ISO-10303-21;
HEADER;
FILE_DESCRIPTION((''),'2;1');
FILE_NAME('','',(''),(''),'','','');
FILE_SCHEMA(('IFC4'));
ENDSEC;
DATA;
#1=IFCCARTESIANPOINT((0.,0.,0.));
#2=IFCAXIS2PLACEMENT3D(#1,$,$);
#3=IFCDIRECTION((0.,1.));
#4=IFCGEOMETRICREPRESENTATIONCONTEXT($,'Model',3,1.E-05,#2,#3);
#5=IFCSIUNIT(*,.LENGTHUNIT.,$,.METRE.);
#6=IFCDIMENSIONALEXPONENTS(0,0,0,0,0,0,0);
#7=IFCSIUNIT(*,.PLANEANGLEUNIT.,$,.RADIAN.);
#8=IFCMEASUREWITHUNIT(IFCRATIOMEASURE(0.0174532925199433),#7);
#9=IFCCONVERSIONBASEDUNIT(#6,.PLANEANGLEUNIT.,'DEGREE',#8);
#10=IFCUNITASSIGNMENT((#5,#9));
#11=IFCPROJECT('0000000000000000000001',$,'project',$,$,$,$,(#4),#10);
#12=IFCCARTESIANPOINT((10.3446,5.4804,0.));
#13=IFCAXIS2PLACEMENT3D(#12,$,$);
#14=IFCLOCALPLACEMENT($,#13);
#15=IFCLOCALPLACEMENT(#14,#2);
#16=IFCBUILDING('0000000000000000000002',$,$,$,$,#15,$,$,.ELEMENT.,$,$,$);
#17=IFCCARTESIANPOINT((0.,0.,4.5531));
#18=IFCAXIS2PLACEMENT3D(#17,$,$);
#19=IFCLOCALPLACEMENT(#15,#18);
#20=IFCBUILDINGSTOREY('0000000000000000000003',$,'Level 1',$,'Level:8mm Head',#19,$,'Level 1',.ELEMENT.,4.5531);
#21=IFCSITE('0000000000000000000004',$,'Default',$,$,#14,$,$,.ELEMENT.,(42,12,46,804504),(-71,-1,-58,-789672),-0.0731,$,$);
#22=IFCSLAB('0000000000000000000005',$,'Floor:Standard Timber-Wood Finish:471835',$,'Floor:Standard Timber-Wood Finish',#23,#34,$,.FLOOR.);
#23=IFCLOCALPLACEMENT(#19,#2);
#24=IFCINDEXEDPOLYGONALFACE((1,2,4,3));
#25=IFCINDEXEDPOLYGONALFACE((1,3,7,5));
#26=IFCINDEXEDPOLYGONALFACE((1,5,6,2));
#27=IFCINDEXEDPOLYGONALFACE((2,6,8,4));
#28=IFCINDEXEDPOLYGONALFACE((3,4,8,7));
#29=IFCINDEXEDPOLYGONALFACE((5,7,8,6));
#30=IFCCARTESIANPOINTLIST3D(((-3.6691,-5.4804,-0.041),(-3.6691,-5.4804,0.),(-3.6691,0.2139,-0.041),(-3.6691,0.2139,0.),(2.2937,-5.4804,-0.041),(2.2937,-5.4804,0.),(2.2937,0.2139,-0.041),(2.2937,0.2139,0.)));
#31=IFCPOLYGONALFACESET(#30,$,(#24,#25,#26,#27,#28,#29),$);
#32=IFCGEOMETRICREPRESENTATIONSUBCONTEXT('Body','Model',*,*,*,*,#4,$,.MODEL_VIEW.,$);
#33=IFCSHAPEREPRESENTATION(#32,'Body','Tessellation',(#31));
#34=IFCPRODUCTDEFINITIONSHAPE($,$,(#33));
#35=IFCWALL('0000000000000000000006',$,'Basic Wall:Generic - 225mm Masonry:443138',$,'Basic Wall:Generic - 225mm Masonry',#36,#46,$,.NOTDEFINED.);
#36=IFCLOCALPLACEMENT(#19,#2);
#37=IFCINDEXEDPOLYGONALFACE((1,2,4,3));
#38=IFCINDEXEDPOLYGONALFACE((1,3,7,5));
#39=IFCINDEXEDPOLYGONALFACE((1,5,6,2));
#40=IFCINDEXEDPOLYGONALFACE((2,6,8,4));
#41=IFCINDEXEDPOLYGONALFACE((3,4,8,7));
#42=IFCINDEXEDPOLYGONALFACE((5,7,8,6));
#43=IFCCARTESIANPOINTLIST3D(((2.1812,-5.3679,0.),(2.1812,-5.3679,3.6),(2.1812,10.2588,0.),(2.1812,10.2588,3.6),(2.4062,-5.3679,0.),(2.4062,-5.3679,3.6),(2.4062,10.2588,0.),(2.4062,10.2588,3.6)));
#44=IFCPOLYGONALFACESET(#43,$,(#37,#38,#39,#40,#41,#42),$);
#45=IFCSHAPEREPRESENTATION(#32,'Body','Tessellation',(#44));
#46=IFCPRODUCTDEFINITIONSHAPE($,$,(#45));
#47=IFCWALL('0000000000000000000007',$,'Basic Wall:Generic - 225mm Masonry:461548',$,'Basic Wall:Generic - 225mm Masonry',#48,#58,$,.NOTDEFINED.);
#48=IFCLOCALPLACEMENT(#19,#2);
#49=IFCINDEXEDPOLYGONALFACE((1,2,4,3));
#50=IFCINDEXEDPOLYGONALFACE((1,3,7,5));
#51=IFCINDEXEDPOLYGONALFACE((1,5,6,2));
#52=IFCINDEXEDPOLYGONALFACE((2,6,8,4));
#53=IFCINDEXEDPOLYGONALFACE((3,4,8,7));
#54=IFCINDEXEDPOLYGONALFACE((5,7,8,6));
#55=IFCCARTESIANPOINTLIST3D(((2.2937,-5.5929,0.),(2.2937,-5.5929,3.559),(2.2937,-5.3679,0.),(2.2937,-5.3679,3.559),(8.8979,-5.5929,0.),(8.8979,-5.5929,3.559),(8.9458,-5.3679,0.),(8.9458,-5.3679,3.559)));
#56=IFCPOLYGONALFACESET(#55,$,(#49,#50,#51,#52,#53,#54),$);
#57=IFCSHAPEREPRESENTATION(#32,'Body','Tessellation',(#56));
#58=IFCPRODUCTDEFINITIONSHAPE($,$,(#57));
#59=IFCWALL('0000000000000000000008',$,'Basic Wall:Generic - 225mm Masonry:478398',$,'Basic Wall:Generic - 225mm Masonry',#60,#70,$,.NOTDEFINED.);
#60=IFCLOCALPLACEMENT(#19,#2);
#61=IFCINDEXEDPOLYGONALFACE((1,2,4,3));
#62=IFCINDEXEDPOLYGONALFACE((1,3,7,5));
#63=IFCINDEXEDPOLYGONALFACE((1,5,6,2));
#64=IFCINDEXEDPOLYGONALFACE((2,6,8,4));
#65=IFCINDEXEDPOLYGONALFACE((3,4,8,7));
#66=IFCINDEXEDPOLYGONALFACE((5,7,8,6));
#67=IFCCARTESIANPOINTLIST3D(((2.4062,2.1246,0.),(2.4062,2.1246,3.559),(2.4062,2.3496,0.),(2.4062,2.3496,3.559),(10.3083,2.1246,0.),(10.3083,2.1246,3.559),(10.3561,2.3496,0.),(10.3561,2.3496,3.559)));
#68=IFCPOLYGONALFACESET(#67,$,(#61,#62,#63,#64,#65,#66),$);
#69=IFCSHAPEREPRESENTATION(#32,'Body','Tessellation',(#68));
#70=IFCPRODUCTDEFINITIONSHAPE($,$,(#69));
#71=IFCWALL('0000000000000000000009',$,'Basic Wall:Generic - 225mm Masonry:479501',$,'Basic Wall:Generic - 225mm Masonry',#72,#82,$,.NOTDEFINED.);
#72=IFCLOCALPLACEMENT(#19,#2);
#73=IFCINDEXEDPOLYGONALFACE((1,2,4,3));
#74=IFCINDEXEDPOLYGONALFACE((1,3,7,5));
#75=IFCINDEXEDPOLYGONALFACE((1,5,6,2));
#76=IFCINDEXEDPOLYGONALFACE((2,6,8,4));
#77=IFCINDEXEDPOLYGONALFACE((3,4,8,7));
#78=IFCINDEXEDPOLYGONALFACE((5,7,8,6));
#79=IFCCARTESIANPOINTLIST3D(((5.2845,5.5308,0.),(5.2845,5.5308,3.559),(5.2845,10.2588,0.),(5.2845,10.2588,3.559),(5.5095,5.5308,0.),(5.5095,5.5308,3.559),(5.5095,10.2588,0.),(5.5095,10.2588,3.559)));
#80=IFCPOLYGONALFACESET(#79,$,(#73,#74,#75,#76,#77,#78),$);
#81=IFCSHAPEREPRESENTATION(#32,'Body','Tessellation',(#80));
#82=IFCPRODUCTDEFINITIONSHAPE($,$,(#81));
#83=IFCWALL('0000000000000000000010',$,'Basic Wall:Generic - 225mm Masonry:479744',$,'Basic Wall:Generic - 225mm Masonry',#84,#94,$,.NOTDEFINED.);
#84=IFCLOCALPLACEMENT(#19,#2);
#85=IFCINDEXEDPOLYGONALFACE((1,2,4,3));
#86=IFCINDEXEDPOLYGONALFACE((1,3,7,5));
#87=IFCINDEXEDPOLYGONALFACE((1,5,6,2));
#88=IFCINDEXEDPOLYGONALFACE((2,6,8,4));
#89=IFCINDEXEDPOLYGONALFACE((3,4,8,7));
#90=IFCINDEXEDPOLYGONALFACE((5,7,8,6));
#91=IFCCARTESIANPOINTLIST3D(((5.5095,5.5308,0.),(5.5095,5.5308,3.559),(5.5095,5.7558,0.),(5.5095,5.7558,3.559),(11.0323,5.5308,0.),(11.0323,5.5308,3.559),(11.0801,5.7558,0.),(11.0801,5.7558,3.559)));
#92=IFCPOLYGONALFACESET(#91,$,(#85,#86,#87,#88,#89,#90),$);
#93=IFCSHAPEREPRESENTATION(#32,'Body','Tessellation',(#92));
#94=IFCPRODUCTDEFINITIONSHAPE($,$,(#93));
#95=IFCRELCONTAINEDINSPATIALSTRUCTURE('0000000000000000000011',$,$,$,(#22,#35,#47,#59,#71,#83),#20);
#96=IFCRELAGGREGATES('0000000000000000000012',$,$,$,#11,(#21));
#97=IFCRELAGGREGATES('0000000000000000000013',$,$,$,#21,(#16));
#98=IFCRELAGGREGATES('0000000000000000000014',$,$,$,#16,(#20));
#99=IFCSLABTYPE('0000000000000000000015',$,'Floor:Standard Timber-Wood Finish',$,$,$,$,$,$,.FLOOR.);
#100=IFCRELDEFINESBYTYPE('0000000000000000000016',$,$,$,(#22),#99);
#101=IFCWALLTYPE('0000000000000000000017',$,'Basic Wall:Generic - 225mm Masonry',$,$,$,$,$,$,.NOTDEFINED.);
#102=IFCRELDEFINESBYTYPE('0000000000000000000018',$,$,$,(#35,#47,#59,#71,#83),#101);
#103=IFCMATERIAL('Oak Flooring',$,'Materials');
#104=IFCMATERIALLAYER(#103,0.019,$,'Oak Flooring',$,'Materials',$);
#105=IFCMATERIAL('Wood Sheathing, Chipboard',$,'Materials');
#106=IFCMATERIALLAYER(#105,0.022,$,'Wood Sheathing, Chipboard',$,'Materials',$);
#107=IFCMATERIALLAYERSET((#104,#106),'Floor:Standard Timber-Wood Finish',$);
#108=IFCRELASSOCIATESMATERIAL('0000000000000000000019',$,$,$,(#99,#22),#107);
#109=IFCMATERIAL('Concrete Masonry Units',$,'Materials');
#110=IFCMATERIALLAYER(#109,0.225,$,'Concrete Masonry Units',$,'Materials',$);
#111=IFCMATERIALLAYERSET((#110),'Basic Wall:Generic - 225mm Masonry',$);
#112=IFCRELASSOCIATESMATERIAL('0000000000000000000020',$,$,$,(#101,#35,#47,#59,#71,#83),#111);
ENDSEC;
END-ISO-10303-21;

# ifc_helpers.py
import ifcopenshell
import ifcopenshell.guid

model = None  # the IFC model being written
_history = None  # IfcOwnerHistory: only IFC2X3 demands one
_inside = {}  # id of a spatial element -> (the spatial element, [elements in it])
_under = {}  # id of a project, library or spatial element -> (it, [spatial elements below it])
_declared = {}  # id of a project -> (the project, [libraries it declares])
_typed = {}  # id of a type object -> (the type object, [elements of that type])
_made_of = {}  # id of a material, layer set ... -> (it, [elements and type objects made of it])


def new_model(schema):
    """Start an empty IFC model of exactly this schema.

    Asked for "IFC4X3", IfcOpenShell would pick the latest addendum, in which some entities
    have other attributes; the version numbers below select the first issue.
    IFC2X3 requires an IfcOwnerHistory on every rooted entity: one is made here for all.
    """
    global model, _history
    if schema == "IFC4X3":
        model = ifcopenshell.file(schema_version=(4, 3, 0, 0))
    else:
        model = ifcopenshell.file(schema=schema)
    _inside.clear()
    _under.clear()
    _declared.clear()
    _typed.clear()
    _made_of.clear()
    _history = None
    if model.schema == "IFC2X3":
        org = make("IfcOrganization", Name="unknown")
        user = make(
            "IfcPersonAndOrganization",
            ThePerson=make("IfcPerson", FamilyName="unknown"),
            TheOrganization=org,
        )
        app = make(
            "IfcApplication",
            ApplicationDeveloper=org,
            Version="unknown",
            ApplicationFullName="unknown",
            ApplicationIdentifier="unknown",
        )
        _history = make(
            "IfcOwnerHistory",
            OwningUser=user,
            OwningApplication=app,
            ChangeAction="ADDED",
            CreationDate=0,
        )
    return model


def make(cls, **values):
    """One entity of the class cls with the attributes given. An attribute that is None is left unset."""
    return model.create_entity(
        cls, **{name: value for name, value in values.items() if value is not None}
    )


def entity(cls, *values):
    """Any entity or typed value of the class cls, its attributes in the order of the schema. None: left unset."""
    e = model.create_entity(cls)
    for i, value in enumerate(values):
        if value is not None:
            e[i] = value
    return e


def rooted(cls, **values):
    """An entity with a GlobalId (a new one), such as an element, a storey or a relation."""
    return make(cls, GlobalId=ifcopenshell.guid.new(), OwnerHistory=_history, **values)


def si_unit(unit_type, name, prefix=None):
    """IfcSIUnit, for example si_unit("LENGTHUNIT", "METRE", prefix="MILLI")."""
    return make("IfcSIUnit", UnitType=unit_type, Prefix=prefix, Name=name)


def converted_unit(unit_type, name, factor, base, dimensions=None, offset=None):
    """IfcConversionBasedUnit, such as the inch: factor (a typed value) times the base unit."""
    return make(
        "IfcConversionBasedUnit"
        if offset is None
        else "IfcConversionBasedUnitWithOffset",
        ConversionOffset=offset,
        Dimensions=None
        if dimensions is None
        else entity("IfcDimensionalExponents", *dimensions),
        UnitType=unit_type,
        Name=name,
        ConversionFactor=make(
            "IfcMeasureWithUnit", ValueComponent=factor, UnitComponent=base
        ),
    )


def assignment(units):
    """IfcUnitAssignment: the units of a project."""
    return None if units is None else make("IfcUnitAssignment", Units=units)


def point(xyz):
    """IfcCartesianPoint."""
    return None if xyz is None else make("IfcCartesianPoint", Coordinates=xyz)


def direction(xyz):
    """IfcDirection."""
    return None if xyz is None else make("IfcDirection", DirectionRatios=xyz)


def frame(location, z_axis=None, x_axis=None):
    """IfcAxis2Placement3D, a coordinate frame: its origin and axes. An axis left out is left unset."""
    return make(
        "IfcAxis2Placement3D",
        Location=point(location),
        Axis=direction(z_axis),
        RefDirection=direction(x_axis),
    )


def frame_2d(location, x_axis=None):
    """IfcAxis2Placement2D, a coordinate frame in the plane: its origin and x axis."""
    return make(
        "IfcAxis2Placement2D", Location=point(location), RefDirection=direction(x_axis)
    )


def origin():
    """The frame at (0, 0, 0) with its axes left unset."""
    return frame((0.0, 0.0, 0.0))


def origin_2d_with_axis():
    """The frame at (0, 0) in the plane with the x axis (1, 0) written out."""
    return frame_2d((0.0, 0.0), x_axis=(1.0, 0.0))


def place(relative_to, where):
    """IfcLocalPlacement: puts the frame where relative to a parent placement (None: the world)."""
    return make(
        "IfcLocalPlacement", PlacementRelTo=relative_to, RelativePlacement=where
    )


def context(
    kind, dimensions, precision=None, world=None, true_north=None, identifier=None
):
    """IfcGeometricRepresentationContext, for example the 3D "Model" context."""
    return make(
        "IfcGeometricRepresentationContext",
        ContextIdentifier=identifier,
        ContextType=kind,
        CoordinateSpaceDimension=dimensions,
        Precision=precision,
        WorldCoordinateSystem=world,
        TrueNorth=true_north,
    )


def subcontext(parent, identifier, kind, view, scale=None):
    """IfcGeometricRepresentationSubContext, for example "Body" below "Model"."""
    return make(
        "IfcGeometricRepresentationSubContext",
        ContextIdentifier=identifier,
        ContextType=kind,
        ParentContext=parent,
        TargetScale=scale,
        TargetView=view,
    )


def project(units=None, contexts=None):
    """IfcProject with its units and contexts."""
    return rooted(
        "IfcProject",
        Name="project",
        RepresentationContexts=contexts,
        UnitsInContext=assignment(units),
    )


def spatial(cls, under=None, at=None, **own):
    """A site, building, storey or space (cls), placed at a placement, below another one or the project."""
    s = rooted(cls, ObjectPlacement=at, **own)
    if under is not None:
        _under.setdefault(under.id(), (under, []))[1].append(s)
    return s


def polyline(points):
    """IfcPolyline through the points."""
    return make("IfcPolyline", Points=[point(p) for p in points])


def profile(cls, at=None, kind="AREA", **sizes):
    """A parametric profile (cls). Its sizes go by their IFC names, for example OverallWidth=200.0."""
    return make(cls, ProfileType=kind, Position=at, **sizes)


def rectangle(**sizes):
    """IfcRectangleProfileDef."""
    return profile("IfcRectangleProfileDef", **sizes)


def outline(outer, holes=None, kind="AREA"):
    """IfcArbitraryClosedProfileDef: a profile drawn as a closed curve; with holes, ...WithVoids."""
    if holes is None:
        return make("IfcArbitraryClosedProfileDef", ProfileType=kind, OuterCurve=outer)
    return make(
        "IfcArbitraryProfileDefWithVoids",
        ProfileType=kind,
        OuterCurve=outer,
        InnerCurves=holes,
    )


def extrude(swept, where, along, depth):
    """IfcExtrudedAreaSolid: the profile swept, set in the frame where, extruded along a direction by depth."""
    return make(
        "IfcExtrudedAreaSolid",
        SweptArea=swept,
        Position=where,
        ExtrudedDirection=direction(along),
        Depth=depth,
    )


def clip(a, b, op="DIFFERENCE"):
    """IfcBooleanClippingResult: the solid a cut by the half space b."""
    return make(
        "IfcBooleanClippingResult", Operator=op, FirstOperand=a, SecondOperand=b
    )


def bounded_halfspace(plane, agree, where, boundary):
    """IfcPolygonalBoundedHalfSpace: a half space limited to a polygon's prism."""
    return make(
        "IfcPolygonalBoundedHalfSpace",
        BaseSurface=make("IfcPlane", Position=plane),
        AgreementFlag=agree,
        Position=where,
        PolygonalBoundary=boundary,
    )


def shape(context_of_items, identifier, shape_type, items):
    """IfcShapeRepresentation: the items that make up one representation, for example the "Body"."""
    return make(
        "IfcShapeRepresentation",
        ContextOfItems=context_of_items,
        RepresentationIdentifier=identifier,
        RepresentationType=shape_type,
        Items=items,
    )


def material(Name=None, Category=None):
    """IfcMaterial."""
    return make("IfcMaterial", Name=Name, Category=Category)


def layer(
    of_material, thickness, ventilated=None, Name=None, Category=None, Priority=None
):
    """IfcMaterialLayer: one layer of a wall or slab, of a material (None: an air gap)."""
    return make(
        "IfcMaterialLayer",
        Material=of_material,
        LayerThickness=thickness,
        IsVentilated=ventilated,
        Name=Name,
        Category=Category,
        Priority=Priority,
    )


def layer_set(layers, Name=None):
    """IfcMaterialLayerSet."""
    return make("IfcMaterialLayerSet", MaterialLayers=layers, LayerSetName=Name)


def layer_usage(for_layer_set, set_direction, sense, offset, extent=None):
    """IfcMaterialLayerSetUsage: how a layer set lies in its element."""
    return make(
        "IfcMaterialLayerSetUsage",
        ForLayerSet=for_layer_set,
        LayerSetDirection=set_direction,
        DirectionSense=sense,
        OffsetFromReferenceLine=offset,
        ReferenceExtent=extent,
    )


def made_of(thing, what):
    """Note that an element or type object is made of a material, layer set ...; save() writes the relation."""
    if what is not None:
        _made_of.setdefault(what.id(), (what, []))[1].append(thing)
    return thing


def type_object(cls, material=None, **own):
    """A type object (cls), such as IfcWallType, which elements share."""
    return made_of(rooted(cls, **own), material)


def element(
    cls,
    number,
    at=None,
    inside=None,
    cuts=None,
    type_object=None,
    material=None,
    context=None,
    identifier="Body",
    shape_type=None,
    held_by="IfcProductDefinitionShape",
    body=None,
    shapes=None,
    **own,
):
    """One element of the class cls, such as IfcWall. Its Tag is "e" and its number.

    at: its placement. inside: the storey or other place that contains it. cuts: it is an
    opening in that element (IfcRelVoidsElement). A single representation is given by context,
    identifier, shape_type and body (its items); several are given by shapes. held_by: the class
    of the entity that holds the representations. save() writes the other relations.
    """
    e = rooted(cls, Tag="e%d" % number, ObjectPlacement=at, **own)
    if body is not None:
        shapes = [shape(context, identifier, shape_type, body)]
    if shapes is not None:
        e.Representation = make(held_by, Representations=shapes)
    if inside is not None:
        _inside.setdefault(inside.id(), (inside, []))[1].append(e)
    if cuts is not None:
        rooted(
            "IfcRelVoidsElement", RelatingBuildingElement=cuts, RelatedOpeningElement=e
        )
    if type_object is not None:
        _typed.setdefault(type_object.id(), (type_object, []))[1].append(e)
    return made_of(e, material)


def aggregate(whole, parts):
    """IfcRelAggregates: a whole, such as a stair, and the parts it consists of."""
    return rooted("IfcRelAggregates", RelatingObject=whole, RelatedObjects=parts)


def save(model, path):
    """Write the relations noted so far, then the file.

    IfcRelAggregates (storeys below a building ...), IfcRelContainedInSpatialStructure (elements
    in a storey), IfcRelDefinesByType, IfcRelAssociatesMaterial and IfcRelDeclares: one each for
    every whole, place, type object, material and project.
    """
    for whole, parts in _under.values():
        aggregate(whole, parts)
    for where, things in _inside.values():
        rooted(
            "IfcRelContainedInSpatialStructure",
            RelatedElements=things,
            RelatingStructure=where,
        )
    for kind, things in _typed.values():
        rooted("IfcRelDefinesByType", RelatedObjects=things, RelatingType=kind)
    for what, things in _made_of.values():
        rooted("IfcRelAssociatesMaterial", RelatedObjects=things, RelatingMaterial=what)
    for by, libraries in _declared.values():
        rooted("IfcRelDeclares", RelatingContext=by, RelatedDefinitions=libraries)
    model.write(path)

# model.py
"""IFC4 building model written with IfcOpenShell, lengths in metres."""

from ifc_helpers import new_model, entity, si_unit, converted_unit, direction, frame, frame_2d, origin, origin_2d_with_axis, place, context, subcontext, project, spatial, polyline, rectangle, outline, extrude, clip, bounded_halfspace, material, layer, layer_set, layer_usage, type_object, element, save


model = new_model("IFC4")

# Units and contexts
model_context = context("Model", 3, precision=1e-05, world=origin(), true_north=direction((0.0, 1.0)))
body_context = subcontext(model_context, "Body", "Model", "MODEL_VIEW")
ifc_project = project(units=[si_unit("LENGTHUNIT", "METRE"), converted_unit("PLANEANGLEUNIT", "DEGREE", entity("IfcRatioMeasure", 0.0174532925199433), si_unit("PLANEANGLEUNIT", "RADIAN"), dimensions=[0, 0, 0, 0, 0, 0, 0])], contexts=[model_context])

# Site, building, storey
site_placement = place(None, frame((10.3446, 5.4804, 0.0)))
site = spatial("IfcSite", under=ifc_project, at=site_placement, Name="Default", CompositionType="ELEMENT", RefLatitude=(42, 12, 46, 804504), RefLongitude=(-71, -1, -58, -789672), RefElevation=-0.0731)
building_placement = place(site_placement, origin())
building = spatial("IfcBuilding", under=site, at=building_placement, CompositionType="ELEMENT")
storey_placement = place(building_placement, frame((0.0, 0.0, 4.5531)))
storey = spatial("IfcBuildingStorey", under=building, at=storey_placement, Name="Level 1", ObjectType="Level:8mm Head", LongName="Level 1", CompositionType="ELEMENT", Elevation=4.5531)

# Slab
ifc_material_1 = material(Name="Oak Flooring", Category="Materials")
ifc_layer_1 = layer(ifc_material_1, 0.019, Name="Oak Flooring", Category="Materials")
ifc_material_2 = material(Name="Wood Sheathing, Chipboard", Category="Materials")
ifc_layer_2 = layer(ifc_material_2, 0.022, Name="Wood Sheathing, Chipboard", Category="Materials")
ifc_layer_set_1 = layer_set([ifc_layer_1, ifc_layer_2], Name="Floor:Standard Timber-Wood Finish")
ifc_layer_usage_1 = layer_usage(ifc_layer_set_1, "AXIS3", "POSITIVE", 0.0)
slab_type_1 = type_object("IfcSlabType", Name="Floor:Standard Timber-Wood Finish", PredefinedType="FLOOR", material=ifc_layer_set_1)
slab_1_placement = place(storey_placement, origin())
element("IfcSlab", 1, at=slab_1_placement, inside=storey, type_object=slab_type_1, material=ifc_layer_usage_1, Name="Floor:Standard Timber-Wood Finish:471835", ObjectType="Floor:Standard Timber-Wood Finish", PredefinedType="FLOOR", context=body_context, shape_type="SweptSolid", body=[
    extrude(rectangle(XDim=5.6943, YDim=5.9627, at=origin_2d_with_axis()), frame((-0.6877, -2.6333, 0.0), z_axis=(0.0, 0.0, -1.0), x_axis=(0.0, 1.0, 0.0)), (0.0, 0.0, 1.0), 0.041),
])

# Walls
ifc_material_3 = material(Name="Concrete Masonry Units", Category="Materials")
ifc_layer_3 = layer(ifc_material_3, 0.225, Name="Concrete Masonry Units", Category="Materials")
ifc_layer_set_2 = layer_set([ifc_layer_3], Name="Basic Wall:Generic - 225mm Masonry")
wall_type = type_object("IfcWallType", Name="Basic Wall:Generic - 225mm Masonry", PredefinedType="NOTDEFINED", material=ifc_layer_set_2)
ifc_layer_usage_2 = layer_usage(ifc_layer_set_2, "AXIS2", "NEGATIVE", 0.1125)
wall_1_placement = place(storey_placement, frame((2.2937, 10.2588, 0.0), z_axis=(0.0, 0.0, 1.0), x_axis=(0.0, -1.0, 0.0)))
element("IfcWall", 2, at=wall_1_placement, inside=storey, type_object=wall_type, material=ifc_layer_usage_2, Name="Basic Wall:Generic - 225mm Masonry:443138", ObjectType="Basic Wall:Generic - 225mm Masonry", PredefinedType="NOTDEFINED", context=body_context, shape_type="SweptSolid", body=[
    extrude(rectangle(XDim=15.6267, YDim=0.225, at=frame_2d((7.8134, 0.0), x_axis=(-1.0, 0.0))), origin(), (0.0, 0.0, 1.0), 3.6),
])
ifc_layer_usage_3 = layer_usage(ifc_layer_set_2, "AXIS2", "NEGATIVE", 0.1125)
wall_2_placement = place(storey_placement, frame((2.2937, -5.4804, 0.0)))
element("IfcWall", 3, at=wall_2_placement, inside=storey, type_object=wall_type, material=ifc_layer_usage_3, Name="Basic Wall:Generic - 225mm Masonry:461548", ObjectType="Basic Wall:Generic - 225mm Masonry", PredefinedType="NOTDEFINED", context=body_context, shape_type="Clipping", body=[
    clip(extrude(outline(polyline([(6.6043, -0.1125), (6.6521, 0.1125), (6.4221, 0.1125), (0.1125, 0.1125), (0.0, 0.1125), (0.0, -0.1125), (6.6043, -0.1125)])), origin(), (0.0, 0.0, 1.0), 3.559), bounded_halfspace(frame((6.5371, 0.1125, 3.559), z_axis=(0.0, 0.0, -1.0), x_axis=(-1.0, 0.0, 0.0)), True, frame((6.5371, 0.1125, 3.559)), polyline([(0.0, 0.0), (-0.115, 0.0), (-6.4246, 0.0), (-6.5371, 0.0), (-6.5371, -0.1125), (-0.0239, -0.1125), (0.0, 0.0)]))),
])
ifc_layer_usage_4 = layer_usage(ifc_layer_set_2, "AXIS2", "NEGATIVE", 0.1125)
wall_3_placement = place(storey_placement, frame((2.4062, 2.2371, 0.0)))
element("IfcWall", 4, at=wall_3_placement, inside=storey, type_object=wall_type, material=ifc_layer_usage_4, Name="Basic Wall:Generic - 225mm Masonry:478398", ObjectType="Basic Wall:Generic - 225mm Masonry", PredefinedType="NOTDEFINED", context=body_context, shape_type="Clipping", body=[
    clip(clip(extrude(outline(polyline([(7.9022, -0.1125), (7.95, 0.1125), (0.0, 0.1125), (0.0, -0.1125), (7.9022, -0.1125)])), origin(), (0.0, 0.0, 1.0), 3.559), bounded_halfspace(frame((7.9261, 0.0, 3.559), z_axis=(0.0, 0.0, -1.0), x_axis=(-0.207912, -0.978148, 0.0)), True, frame((7.9261, 0.0, 3.559)), polyline([(0.0, 0.0), (0.0239, 0.1125), (-7.9261, 0.1125), (-7.9261, 0.0), (0.0, 0.0)]))), bounded_halfspace(frame((0.0, -0.1125, 3.559), z_axis=(0.0, 0.0, -1.0), x_axis=(-1.0, 0.0, 0.0)), True, frame((0.0, -0.1125, 3.559)), polyline([(0.0, 0.0), (7.9022, 0.0), (7.9261, 0.1125), (0.0, 0.1125), (0.0, 0.0)]))),
])
ifc_layer_usage_5 = layer_usage(ifc_layer_set_2, "AXIS2", "NEGATIVE", 0.1125)
wall_4_placement = place(storey_placement, frame((5.397, 10.2588, 0.0), z_axis=(0.0, 0.0, 1.0), x_axis=(0.0, -1.0, 0.0)))
element("IfcWall", 5, at=wall_4_placement, inside=storey, type_object=wall_type, material=ifc_layer_usage_5, Name="Basic Wall:Generic - 225mm Masonry:479501", ObjectType="Basic Wall:Generic - 225mm Masonry", PredefinedType="NOTDEFINED", context=body_context, shape_type="Clipping", body=[
    clip(extrude(rectangle(XDim=4.728, YDim=0.225, at=frame_2d((2.364, 0.0), x_axis=(-1.0, 0.0))), origin(), (0.0, 0.0, 1.0), 3.559), bounded_halfspace(frame((0.0, -0.1125, 3.559), z_axis=(0.0, 0.0, -1.0), x_axis=(0.978148, -0.207912, 0.0)), True, frame((0.0, -0.1125, 3.559)), polyline([(0.0, 0.0), (4.728, 0.0), (4.728, 0.225), (4.503, 0.225), (0.0, 0.225), (0.0, 0.0)]))),
])
ifc_layer_usage_6 = layer_usage(ifc_layer_set_2, "AXIS2", "NEGATIVE", 0.1125)
wall_5_placement = place(storey_placement, frame((5.5095, 5.6433, 0.0)))
element("IfcWall", 6, at=wall_5_placement, inside=storey, type_object=wall_type, material=ifc_layer_usage_6, Name="Basic Wall:Generic - 225mm Masonry:479744", ObjectType="Basic Wall:Generic - 225mm Masonry", PredefinedType="NOTDEFINED", context=body_context, shape_type="Clipping", body=[
    clip(extrude(outline(polyline([(5.5228, -0.1125), (5.5706, 0.1125), (0.0, 0.1125), (0.0, -0.1125), (5.5228, -0.1125)])), origin(), (0.0, 0.0, 1.0), 3.559), bounded_halfspace(frame((0.0, -0.1125, 3.559), z_axis=(0.0, 0.0, -1.0), x_axis=(-0.207912, -0.978148, 0.0)), True, frame((0.0, -0.1125, 3.559)), polyline([(0.0, 0.0), (5.5228, 0.0), (5.5706, 0.225), (0.0, 0.225), (0.0, 0.0)]))),
])

save(model, "model.ifc")
